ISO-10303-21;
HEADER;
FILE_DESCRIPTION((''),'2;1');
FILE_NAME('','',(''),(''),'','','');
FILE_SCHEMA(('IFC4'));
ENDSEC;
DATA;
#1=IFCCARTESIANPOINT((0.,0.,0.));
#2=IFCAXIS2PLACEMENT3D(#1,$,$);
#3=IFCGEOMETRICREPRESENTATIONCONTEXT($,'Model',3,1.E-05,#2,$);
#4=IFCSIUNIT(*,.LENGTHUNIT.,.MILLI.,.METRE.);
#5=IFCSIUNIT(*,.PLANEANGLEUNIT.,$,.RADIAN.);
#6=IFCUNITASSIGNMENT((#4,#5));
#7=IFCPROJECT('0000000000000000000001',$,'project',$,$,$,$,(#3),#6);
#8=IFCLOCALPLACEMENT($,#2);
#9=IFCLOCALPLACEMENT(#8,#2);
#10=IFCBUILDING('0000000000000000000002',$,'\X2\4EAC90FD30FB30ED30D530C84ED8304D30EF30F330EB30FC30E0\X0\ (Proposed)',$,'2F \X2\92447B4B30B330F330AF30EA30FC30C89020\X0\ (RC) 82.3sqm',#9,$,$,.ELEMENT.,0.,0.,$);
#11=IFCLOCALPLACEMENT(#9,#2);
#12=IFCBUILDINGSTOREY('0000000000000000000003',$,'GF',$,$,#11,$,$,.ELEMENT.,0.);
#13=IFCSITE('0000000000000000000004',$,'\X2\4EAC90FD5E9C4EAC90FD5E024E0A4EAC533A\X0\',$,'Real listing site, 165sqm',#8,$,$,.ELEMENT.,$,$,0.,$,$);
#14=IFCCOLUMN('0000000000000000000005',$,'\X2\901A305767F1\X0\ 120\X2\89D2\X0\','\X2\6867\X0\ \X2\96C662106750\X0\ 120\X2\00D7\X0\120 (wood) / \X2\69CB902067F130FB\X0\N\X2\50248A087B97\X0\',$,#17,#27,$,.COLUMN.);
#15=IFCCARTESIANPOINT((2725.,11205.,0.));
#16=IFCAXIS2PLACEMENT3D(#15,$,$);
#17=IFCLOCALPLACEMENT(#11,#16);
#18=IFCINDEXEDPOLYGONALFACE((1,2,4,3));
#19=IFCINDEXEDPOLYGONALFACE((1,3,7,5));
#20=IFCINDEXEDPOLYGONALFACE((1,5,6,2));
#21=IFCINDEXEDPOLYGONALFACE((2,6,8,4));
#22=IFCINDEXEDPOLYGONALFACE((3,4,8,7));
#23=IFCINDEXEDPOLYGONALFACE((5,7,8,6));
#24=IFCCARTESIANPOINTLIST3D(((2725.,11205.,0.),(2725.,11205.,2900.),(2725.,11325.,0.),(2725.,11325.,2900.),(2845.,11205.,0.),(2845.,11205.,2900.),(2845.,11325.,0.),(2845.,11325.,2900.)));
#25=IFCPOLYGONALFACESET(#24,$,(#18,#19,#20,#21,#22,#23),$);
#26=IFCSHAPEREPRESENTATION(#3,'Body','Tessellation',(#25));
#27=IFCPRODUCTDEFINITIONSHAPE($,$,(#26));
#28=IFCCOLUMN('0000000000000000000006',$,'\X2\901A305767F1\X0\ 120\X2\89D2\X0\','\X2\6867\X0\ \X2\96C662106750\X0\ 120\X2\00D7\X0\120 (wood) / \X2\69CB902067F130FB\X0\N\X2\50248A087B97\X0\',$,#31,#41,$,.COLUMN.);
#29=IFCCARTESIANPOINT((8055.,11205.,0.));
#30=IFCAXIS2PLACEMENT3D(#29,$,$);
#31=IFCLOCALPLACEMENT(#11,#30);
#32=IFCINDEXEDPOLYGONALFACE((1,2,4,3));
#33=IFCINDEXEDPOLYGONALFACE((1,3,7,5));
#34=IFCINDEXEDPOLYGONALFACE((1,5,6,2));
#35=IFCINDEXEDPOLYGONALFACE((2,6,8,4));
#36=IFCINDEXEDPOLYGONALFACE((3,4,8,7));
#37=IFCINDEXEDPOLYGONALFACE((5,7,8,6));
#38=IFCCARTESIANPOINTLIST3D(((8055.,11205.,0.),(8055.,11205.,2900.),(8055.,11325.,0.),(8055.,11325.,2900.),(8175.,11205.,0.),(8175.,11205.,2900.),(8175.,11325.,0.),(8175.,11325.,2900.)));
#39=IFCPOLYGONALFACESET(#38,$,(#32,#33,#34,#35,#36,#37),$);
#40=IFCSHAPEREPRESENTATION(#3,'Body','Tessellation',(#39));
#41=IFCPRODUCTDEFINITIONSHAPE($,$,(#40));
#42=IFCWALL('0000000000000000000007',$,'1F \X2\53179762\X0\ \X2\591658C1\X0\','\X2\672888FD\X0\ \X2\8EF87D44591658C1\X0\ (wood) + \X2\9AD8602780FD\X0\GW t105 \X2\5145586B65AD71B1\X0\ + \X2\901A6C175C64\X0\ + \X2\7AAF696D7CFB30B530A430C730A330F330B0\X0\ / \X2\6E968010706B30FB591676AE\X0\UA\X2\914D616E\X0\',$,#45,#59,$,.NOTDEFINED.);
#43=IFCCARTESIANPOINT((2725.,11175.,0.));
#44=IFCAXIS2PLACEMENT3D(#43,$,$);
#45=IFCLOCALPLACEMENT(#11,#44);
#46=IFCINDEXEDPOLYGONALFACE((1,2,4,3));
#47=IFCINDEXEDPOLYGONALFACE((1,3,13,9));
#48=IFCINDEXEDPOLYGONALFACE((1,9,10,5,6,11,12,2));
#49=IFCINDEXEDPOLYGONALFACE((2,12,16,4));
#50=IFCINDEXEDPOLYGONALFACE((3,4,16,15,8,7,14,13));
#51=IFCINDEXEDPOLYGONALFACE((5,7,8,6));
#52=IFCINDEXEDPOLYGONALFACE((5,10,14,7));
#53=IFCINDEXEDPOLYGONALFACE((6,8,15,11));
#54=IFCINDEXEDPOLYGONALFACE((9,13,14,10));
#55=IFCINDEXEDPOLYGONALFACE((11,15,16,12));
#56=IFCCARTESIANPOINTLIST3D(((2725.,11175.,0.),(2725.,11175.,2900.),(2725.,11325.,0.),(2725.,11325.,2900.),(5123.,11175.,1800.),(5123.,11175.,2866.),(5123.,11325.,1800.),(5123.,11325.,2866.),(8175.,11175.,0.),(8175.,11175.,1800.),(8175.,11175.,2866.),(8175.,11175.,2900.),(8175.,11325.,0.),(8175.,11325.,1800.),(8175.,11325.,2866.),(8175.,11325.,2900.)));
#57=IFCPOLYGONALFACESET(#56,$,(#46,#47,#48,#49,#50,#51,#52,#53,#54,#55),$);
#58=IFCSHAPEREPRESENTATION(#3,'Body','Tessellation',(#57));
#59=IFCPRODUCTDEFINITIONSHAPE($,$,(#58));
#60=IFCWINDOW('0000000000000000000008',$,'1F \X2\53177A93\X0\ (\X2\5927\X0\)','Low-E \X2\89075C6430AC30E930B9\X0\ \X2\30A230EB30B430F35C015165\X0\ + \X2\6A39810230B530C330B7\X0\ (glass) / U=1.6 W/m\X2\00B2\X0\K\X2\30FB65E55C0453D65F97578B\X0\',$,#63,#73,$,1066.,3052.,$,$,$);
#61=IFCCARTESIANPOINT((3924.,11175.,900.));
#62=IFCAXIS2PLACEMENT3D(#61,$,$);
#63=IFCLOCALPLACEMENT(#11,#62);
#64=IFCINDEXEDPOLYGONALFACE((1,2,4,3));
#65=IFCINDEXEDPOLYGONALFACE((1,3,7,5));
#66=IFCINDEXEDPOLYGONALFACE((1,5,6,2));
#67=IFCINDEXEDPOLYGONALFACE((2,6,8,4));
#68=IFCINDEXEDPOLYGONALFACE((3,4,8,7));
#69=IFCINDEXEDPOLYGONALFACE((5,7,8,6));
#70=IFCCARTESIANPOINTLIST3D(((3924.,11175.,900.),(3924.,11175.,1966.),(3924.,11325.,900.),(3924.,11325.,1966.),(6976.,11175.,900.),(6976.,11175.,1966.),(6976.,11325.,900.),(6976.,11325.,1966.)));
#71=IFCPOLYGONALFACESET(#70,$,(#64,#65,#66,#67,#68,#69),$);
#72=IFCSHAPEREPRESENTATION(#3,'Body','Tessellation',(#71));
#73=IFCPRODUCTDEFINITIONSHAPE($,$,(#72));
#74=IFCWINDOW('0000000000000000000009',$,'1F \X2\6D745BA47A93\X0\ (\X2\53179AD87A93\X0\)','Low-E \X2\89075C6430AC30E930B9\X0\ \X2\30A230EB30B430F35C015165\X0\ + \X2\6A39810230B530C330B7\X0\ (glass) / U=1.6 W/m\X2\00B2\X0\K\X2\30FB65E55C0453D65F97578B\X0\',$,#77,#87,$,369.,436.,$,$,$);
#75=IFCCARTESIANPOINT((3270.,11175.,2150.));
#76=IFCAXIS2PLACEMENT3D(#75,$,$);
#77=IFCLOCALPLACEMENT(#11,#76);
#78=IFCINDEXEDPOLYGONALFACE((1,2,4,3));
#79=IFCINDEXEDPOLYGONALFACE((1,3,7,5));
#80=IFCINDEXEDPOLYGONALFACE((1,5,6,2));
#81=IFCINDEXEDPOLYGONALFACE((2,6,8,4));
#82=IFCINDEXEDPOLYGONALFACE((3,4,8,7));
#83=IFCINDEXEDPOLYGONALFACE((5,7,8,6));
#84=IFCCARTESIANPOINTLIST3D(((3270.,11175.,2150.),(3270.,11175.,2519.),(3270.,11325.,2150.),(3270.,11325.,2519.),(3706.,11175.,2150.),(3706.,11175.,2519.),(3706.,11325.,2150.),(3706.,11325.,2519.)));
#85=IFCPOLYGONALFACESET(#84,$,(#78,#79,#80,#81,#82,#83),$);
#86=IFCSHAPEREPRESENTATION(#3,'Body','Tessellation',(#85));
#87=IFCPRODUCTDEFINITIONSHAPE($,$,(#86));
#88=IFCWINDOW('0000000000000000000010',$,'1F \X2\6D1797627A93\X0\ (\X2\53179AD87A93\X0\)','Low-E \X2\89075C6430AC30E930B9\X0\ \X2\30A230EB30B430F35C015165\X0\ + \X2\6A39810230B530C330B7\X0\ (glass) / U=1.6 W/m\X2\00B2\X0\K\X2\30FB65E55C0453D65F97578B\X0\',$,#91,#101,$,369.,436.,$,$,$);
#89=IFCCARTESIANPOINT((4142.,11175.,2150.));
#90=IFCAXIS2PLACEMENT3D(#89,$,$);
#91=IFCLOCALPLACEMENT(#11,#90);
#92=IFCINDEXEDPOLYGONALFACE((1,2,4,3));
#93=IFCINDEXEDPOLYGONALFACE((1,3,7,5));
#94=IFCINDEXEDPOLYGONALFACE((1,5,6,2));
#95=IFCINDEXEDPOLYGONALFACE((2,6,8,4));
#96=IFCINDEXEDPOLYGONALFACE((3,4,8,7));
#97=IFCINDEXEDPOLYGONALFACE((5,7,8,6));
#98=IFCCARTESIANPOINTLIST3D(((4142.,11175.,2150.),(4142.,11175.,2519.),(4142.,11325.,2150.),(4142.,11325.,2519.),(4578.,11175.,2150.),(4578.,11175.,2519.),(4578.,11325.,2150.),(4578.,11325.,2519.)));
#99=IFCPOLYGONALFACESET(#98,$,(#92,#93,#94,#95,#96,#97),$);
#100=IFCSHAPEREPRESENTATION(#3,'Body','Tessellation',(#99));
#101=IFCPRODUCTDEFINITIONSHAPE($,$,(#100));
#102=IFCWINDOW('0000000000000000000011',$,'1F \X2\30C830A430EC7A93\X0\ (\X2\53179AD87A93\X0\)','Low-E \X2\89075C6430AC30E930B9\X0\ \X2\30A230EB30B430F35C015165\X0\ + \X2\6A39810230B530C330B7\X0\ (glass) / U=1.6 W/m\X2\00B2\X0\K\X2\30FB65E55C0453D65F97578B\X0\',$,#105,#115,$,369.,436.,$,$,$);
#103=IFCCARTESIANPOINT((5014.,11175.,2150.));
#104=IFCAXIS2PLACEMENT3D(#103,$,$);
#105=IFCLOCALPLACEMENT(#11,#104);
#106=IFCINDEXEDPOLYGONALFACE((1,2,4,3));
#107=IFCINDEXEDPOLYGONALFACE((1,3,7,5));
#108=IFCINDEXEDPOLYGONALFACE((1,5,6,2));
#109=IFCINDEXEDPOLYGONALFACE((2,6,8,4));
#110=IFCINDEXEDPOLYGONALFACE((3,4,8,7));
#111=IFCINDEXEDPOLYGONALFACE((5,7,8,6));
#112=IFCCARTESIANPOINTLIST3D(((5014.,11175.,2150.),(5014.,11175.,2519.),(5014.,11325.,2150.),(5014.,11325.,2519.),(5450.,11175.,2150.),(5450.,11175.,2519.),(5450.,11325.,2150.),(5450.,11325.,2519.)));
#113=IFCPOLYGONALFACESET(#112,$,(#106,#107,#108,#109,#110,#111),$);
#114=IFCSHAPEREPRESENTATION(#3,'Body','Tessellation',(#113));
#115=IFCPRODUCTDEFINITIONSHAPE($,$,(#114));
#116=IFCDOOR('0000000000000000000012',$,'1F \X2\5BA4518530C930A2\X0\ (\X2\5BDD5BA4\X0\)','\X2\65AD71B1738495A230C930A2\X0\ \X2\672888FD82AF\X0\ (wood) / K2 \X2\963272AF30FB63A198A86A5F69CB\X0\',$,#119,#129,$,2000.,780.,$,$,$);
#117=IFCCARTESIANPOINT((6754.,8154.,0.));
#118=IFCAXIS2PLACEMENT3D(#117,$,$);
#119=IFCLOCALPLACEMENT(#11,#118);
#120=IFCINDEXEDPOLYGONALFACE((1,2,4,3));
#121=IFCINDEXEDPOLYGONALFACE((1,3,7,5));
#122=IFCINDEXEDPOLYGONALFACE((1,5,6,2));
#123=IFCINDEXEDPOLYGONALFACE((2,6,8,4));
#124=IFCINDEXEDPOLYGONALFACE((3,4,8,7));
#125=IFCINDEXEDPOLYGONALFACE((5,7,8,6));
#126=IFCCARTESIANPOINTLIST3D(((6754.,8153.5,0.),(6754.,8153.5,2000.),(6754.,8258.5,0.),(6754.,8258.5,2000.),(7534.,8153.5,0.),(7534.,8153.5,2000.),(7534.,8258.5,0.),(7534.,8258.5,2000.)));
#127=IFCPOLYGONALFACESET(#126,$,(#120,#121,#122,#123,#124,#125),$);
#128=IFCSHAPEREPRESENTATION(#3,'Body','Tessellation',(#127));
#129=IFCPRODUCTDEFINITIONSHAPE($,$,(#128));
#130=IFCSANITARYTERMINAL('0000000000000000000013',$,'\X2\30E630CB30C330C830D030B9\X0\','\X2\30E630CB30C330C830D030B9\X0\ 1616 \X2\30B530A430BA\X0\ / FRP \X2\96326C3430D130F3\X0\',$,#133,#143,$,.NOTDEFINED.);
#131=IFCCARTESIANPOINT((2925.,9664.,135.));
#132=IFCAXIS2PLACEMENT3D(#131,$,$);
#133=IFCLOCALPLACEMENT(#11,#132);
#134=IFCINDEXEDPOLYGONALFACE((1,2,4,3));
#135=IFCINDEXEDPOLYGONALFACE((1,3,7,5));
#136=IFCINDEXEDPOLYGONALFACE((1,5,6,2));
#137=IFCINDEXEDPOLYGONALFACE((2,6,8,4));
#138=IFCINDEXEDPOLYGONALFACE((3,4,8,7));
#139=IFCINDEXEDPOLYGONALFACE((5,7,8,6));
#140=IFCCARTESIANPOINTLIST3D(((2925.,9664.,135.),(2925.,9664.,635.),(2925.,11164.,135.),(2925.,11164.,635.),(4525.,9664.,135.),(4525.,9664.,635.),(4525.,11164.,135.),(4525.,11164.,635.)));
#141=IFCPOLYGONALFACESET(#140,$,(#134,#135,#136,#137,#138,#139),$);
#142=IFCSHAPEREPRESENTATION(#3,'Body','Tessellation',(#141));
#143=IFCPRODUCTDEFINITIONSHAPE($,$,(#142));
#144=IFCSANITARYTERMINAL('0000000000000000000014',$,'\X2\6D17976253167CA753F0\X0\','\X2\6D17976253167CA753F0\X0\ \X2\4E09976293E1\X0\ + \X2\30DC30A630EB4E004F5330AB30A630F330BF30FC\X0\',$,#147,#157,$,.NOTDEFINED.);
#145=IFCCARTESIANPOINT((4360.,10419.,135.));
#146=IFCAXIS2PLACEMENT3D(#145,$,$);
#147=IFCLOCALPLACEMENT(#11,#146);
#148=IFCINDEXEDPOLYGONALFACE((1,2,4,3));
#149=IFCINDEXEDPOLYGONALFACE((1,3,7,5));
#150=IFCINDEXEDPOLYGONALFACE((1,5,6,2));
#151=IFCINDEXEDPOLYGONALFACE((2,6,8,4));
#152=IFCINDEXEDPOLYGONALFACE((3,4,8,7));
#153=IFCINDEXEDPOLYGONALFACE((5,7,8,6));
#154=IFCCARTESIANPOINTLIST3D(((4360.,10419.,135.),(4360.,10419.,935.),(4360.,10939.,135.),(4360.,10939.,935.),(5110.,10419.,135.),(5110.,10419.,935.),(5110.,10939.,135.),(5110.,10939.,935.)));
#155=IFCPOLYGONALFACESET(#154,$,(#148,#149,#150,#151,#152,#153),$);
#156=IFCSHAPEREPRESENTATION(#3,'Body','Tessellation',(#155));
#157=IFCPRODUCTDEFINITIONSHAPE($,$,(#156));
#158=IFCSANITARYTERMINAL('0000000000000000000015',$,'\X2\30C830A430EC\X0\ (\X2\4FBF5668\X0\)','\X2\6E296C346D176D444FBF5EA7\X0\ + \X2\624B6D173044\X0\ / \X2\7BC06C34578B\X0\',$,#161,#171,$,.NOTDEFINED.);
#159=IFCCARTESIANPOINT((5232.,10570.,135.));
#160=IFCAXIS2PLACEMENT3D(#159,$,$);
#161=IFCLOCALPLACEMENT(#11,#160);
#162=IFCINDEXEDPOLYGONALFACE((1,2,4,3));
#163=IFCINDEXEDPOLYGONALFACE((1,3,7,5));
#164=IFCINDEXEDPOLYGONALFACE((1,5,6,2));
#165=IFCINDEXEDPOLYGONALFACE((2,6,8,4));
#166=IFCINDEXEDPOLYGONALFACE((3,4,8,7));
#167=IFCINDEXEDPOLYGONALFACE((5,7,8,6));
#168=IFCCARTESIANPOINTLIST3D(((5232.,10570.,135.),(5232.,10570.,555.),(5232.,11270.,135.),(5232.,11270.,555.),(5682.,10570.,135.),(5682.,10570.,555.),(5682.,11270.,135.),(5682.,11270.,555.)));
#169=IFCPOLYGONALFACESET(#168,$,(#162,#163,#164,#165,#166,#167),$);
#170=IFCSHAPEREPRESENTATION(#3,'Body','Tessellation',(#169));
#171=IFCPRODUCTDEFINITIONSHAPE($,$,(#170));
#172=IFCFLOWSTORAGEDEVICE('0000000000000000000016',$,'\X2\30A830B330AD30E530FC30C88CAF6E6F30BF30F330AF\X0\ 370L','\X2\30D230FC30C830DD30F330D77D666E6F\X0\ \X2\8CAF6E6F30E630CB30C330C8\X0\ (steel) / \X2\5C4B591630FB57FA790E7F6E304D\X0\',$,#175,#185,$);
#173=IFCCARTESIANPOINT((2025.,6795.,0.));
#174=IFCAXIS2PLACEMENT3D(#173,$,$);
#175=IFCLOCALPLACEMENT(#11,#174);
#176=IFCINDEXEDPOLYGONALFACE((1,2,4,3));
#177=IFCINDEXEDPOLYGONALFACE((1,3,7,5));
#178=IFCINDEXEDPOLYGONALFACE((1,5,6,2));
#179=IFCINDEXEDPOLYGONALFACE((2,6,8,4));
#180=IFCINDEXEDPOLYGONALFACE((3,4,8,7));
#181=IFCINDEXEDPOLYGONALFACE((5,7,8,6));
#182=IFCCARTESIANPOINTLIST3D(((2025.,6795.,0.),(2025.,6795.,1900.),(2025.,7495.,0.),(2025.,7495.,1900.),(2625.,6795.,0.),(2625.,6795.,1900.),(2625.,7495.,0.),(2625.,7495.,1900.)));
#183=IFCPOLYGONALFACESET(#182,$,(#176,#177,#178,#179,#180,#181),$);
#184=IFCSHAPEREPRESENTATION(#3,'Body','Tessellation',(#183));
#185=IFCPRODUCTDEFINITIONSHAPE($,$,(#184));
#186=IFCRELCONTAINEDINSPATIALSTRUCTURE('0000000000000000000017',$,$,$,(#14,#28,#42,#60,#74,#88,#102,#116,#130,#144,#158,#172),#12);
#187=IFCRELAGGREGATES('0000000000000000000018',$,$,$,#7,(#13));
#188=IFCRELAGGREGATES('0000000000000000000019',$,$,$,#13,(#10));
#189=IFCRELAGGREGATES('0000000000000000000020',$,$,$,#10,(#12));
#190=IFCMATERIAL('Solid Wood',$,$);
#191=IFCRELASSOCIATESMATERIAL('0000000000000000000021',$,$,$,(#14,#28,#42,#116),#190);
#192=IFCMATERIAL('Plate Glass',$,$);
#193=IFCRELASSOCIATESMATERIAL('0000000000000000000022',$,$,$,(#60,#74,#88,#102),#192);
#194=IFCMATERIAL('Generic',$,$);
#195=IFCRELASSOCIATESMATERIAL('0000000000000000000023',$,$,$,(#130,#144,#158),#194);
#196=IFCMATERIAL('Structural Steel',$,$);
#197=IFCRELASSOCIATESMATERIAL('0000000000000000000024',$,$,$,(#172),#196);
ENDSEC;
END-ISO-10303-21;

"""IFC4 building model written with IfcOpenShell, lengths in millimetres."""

from ifc_helpers import new_model, si_unit, frame, frame_2d, origin, place, context, project, spatial, rectangle, extrude, material, element, fill, save


model = new_model("IFC4")

# Units and contexts
model_context = context("Model", 3, precision=1e-05, world=origin())
ifc_project = project(units=[si_unit("LENGTHUNIT", "METRE", prefix="MILLI"), si_unit("PLANEANGLEUNIT", "RADIAN")], contexts=[model_context])

# Site, building, storey
site_placement = place(None, origin())
site = spatial("IfcSite", under=ifc_project, at=site_placement, Name="京都府京都市上京区", ObjectType="Real listing site, 165sqm", CompositionType="ELEMENT", RefElevation=0.0)
building_placement = place(site_placement, origin())
building = spatial("IfcBuilding", under=site, at=building_placement, Name="京都・ロフト付きワンルーム (Proposed)", ObjectType="2F 鉄筋コンクリート造 (RC) 82.3sqm", CompositionType="ELEMENT", ElevationOfRefHeight=0.0, ElevationOfTerrain=0.0)
storey_placement = place(building_placement, origin())
storey = spatial("IfcBuildingStorey", under=building, at=storey_placement, Name="GF", CompositionType="ELEMENT", Elevation=0.0)

# Columns
ifc_material_1 = material(Name="Solid Wood")
column_1_placement = place(storey_placement, frame((2725.0, 11205.0, 0.0)))
element("IfcColumn", 1, at=column_1_placement, inside=storey, material=ifc_material_1, Name="通し柱 120角", Description="桧 集成材 120×120 (wood) / 構造柱・N値計算", PredefinedType="COLUMN", context=model_context, shape_type="SweptSolid", body=[
    extrude(rectangle(XDim=120.0, YDim=120.0, at=frame_2d((60.0, 60.0))), frame((2725.0, 11205.0, 0.0)), (0.0, 0.0, 1.0), 2900.0),
])
column_2_placement = place(storey_placement, frame((8055.0, 11205.0, 0.0)))
element("IfcColumn", 2, at=column_2_placement, inside=storey, material=ifc_material_1, Name="通し柱 120角", Description="桧 集成材 120×120 (wood) / 構造柱・N値計算", PredefinedType="COLUMN", context=model_context, shape_type="SweptSolid", body=[
    extrude(rectangle(XDim=120.0, YDim=120.0, at=frame_2d((60.0, 60.0))), frame((8055.0, 11205.0, 0.0)), (0.0, 0.0, 1.0), 2900.0),
])

# Wall, openings, windows
wall_1_placement = place(storey_placement, frame((2725.0, 11175.0, 0.0)))
wall_1 = element("IfcWall", 3, at=wall_1_placement, inside=storey, material=ifc_material_1, Name="1F 北面 外壁", Description="木製 軸組外壁 (wood) + 高性能GW t105 充填断熱 + 通気層 + 窯業系サイディング / 準耐火・外皮UA配慮", PredefinedType="NOTDEFINED", context=model_context, shape_type="SweptSolid", body=[
    extrude(rectangle(XDim=5450.0, YDim=150.0, at=frame_2d((2725.0, 75.0))), frame((2725.0, 11175.0, 0.0)), (0.0, 0.0, 1.0), 2900.0),
])
opening_1_placement = place(storey_placement, frame((3924.0, 11175.0, 900.0)))
opening_1 = element("IfcOpeningElement", 4, at=opening_1_placement, cuts=wall_1, PredefinedType="NOTDEFINED", context=model_context, shape_type="SweptSolid", body=[
    extrude(rectangle(XDim=3052.0, YDim=150.0, at=frame_2d((1526.0, 75.0))), frame((3924.0, 11175.0, 900.0)), (0.0, 0.0, 1.0), 1066.0),
])
opening_2_placement = place(storey_placement, frame((3270.0, 11175.0, 2150.0)))
opening_2 = element("IfcOpeningElement", 5, at=opening_2_placement, cuts=wall_1, PredefinedType="NOTDEFINED", context=model_context, shape_type="SweptSolid", body=[
    extrude(rectangle(XDim=436.0, YDim=150.0, at=frame_2d((218.0, 75.0))), frame((3270.0, 11175.0, 2150.0)), (0.0, 0.0, 1.0), 369.0),
])
opening_3_placement = place(storey_placement, frame((4142.0, 11175.0, 2150.0)))
opening_3 = element("IfcOpeningElement", 6, at=opening_3_placement, cuts=wall_1, PredefinedType="NOTDEFINED", context=model_context, shape_type="SweptSolid", body=[
    extrude(rectangle(XDim=436.0, YDim=150.0, at=frame_2d((218.0, 75.0))), frame((4142.0, 11175.0, 2150.0)), (0.0, 0.0, 1.0), 369.0),
])
opening_4_placement = place(storey_placement, frame((5014.0, 11175.0, 2150.0)))
opening_4 = element("IfcOpeningElement", 7, at=opening_4_placement, cuts=wall_1, PredefinedType="NOTDEFINED", context=model_context, shape_type="SweptSolid", body=[
    extrude(rectangle(XDim=436.0, YDim=150.0, at=frame_2d((218.0, 75.0))), frame((5014.0, 11175.0, 2150.0)), (0.0, 0.0, 1.0), 369.0),
])
ifc_material_2 = material(Name="Plate Glass")
window_1_placement = place(storey_placement, frame((3924.0, 11175.0, 900.0)))
window_1 = element("IfcWindow", 8, at=window_1_placement, inside=storey, material=ifc_material_2, Name="1F 北窓 (大)", Description="Low-E 複層ガラス アルゴン封入 + 樹脂サッシ (glass) / U=1.6 W/m²K・日射取得型", OverallHeight=1066.0, OverallWidth=3052.0, context=model_context, shape_type="SweptSolid", body=[
    extrude(rectangle(XDim=3052.0, YDim=150.0, at=frame_2d((1526.0, 75.0))), frame((3924.0, 11175.0, 900.0)), (0.0, 0.0, 1.0), 1066.0),
])
fill(opening_1, window_1)
window_2_placement = place(storey_placement, frame((3270.0, 11175.0, 2150.0)))
window_2 = element("IfcWindow", 9, at=window_2_placement, inside=storey, material=ifc_material_2, Name="1F 浴室窓 (北高窓)", Description="Low-E 複層ガラス アルゴン封入 + 樹脂サッシ (glass) / U=1.6 W/m²K・日射取得型", OverallHeight=369.0, OverallWidth=436.0, context=model_context, shape_type="SweptSolid", body=[
    extrude(rectangle(XDim=436.0, YDim=150.0, at=frame_2d((218.0, 75.0))), frame((3270.0, 11175.0, 2150.0)), (0.0, 0.0, 1.0), 369.0),
])
fill(opening_2, window_2)
window_3_placement = place(storey_placement, frame((4142.0, 11175.0, 2150.0)))
window_3 = element("IfcWindow", 10, at=window_3_placement, inside=storey, material=ifc_material_2, Name="1F 洗面窓 (北高窓)", Description="Low-E 複層ガラス アルゴン封入 + 樹脂サッシ (glass) / U=1.6 W/m²K・日射取得型", OverallHeight=369.0, OverallWidth=436.0, context=model_context, shape_type="SweptSolid", body=[
    extrude(rectangle(XDim=436.0, YDim=150.0, at=frame_2d((218.0, 75.0))), frame((4142.0, 11175.0, 2150.0)), (0.0, 0.0, 1.0), 369.0),
])
fill(opening_3, window_3)
window_4_placement = place(storey_placement, frame((5014.0, 11175.0, 2150.0)))
window_4 = element("IfcWindow", 11, at=window_4_placement, inside=storey, material=ifc_material_2, Name="1F トイレ窓 (北高窓)", Description="Low-E 複層ガラス アルゴン封入 + 樹脂サッシ (glass) / U=1.6 W/m²K・日射取得型", OverallHeight=369.0, OverallWidth=436.0, context=model_context, shape_type="SweptSolid", body=[
    extrude(rectangle(XDim=436.0, YDim=150.0, at=frame_2d((218.0, 75.0))), frame((5014.0, 11175.0, 2150.0)), (0.0, 0.0, 1.0), 369.0),
])
fill(opening_4, window_4)

# Door
door_1_placement = place(storey_placement, frame((6754.0, 8154.0, 0.0)))
element("IfcDoor", 12, at=door_1_placement, inside=storey, material=ifc_material_1, Name="1F 室内ドア (寝室)", Description="断熱玄関ドア 木製芯 (wood) / K2 防犯・採風機構", OverallHeight=2000.0, OverallWidth=780.0, context=model_context, shape_type="SweptSolid", body=[
    extrude(rectangle(XDim=780.0, YDim=105.0, at=frame_2d((390.0, 52.0))), frame((6754.0, 8154.0, 0.0)), (0.0, 0.0, 1.0), 2000.0),
])

# Sanitary terminals
ifc_material_3 = material(Name="Generic")
sanitary_terminal_1_placement = place(storey_placement, frame((2925.0, 9664.0, 135.0)))
element("IfcSanitaryTerminal", 13, at=sanitary_terminal_1_placement, inside=storey, material=ifc_material_3, Name="ユニットバス", Description="ユニットバス 1616 サイズ / FRP 防水パン", PredefinedType="NOTDEFINED", context=model_context, shape_type="SweptSolid", body=[
    extrude(rectangle(XDim=1600.0, YDim=1500.0, at=frame_2d((800.0, 750.0))), frame((2925.0, 9664.0, 135.0)), (0.0, 0.0, 1.0), 500.0),
])
sanitary_terminal_2_placement = place(storey_placement, frame((4360.0, 10419.0, 135.0)))
element("IfcSanitaryTerminal", 14, at=sanitary_terminal_2_placement, inside=storey, material=ifc_material_3, Name="洗面化粧台", Description="洗面化粧台 三面鏡 + ボウル一体カウンター", PredefinedType="NOTDEFINED", context=model_context, shape_type="SweptSolid", body=[
    extrude(rectangle(XDim=750.0, YDim=520.0, at=frame_2d((375.0, 260.0))), frame((4360.0, 10419.0, 135.0)), (0.0, 0.0, 1.0), 800.0),
])
sanitary_terminal_3_placement = place(storey_placement, frame((5232.0, 10570.0, 135.0)))
element("IfcSanitaryTerminal", 15, at=sanitary_terminal_3_placement, inside=storey, material=ifc_material_3, Name="トイレ (便器)", Description="温水洗浄便座 + 手洗い / 節水型", PredefinedType="NOTDEFINED", context=model_context, shape_type="SweptSolid", body=[
    extrude(rectangle(XDim=450.0, YDim=700.0, at=frame_2d((225.0, 350.0))), frame((5232.0, 10570.0, 135.0)), (0.0, 0.0, 1.0), 420.0),
])

# Flow storage device
ifc_material_4 = material(Name="Structural Steel")
flow_storage_device_placement = place(storey_placement, frame((2025.0, 6795.0, 0.0)))
element("IfcFlowStorageDevice", 16, at=flow_storage_device_placement, inside=storey, material=ifc_material_4, Name="エコキュート貯湯タンク 370L", Description="ヒートポンプ給湯 貯湯ユニット (steel) / 屋外・基礎置き", context=model_context, shape_type="SweptSolid", body=[
    extrude(rectangle(XDim=600.0, YDim=700.0, at=frame_2d((300.0, 350.0))), frame((2025.0, 6795.0, 0.0)), (0.0, 0.0, 1.0), 1900.0),
])

save(model, "model.ifc")
